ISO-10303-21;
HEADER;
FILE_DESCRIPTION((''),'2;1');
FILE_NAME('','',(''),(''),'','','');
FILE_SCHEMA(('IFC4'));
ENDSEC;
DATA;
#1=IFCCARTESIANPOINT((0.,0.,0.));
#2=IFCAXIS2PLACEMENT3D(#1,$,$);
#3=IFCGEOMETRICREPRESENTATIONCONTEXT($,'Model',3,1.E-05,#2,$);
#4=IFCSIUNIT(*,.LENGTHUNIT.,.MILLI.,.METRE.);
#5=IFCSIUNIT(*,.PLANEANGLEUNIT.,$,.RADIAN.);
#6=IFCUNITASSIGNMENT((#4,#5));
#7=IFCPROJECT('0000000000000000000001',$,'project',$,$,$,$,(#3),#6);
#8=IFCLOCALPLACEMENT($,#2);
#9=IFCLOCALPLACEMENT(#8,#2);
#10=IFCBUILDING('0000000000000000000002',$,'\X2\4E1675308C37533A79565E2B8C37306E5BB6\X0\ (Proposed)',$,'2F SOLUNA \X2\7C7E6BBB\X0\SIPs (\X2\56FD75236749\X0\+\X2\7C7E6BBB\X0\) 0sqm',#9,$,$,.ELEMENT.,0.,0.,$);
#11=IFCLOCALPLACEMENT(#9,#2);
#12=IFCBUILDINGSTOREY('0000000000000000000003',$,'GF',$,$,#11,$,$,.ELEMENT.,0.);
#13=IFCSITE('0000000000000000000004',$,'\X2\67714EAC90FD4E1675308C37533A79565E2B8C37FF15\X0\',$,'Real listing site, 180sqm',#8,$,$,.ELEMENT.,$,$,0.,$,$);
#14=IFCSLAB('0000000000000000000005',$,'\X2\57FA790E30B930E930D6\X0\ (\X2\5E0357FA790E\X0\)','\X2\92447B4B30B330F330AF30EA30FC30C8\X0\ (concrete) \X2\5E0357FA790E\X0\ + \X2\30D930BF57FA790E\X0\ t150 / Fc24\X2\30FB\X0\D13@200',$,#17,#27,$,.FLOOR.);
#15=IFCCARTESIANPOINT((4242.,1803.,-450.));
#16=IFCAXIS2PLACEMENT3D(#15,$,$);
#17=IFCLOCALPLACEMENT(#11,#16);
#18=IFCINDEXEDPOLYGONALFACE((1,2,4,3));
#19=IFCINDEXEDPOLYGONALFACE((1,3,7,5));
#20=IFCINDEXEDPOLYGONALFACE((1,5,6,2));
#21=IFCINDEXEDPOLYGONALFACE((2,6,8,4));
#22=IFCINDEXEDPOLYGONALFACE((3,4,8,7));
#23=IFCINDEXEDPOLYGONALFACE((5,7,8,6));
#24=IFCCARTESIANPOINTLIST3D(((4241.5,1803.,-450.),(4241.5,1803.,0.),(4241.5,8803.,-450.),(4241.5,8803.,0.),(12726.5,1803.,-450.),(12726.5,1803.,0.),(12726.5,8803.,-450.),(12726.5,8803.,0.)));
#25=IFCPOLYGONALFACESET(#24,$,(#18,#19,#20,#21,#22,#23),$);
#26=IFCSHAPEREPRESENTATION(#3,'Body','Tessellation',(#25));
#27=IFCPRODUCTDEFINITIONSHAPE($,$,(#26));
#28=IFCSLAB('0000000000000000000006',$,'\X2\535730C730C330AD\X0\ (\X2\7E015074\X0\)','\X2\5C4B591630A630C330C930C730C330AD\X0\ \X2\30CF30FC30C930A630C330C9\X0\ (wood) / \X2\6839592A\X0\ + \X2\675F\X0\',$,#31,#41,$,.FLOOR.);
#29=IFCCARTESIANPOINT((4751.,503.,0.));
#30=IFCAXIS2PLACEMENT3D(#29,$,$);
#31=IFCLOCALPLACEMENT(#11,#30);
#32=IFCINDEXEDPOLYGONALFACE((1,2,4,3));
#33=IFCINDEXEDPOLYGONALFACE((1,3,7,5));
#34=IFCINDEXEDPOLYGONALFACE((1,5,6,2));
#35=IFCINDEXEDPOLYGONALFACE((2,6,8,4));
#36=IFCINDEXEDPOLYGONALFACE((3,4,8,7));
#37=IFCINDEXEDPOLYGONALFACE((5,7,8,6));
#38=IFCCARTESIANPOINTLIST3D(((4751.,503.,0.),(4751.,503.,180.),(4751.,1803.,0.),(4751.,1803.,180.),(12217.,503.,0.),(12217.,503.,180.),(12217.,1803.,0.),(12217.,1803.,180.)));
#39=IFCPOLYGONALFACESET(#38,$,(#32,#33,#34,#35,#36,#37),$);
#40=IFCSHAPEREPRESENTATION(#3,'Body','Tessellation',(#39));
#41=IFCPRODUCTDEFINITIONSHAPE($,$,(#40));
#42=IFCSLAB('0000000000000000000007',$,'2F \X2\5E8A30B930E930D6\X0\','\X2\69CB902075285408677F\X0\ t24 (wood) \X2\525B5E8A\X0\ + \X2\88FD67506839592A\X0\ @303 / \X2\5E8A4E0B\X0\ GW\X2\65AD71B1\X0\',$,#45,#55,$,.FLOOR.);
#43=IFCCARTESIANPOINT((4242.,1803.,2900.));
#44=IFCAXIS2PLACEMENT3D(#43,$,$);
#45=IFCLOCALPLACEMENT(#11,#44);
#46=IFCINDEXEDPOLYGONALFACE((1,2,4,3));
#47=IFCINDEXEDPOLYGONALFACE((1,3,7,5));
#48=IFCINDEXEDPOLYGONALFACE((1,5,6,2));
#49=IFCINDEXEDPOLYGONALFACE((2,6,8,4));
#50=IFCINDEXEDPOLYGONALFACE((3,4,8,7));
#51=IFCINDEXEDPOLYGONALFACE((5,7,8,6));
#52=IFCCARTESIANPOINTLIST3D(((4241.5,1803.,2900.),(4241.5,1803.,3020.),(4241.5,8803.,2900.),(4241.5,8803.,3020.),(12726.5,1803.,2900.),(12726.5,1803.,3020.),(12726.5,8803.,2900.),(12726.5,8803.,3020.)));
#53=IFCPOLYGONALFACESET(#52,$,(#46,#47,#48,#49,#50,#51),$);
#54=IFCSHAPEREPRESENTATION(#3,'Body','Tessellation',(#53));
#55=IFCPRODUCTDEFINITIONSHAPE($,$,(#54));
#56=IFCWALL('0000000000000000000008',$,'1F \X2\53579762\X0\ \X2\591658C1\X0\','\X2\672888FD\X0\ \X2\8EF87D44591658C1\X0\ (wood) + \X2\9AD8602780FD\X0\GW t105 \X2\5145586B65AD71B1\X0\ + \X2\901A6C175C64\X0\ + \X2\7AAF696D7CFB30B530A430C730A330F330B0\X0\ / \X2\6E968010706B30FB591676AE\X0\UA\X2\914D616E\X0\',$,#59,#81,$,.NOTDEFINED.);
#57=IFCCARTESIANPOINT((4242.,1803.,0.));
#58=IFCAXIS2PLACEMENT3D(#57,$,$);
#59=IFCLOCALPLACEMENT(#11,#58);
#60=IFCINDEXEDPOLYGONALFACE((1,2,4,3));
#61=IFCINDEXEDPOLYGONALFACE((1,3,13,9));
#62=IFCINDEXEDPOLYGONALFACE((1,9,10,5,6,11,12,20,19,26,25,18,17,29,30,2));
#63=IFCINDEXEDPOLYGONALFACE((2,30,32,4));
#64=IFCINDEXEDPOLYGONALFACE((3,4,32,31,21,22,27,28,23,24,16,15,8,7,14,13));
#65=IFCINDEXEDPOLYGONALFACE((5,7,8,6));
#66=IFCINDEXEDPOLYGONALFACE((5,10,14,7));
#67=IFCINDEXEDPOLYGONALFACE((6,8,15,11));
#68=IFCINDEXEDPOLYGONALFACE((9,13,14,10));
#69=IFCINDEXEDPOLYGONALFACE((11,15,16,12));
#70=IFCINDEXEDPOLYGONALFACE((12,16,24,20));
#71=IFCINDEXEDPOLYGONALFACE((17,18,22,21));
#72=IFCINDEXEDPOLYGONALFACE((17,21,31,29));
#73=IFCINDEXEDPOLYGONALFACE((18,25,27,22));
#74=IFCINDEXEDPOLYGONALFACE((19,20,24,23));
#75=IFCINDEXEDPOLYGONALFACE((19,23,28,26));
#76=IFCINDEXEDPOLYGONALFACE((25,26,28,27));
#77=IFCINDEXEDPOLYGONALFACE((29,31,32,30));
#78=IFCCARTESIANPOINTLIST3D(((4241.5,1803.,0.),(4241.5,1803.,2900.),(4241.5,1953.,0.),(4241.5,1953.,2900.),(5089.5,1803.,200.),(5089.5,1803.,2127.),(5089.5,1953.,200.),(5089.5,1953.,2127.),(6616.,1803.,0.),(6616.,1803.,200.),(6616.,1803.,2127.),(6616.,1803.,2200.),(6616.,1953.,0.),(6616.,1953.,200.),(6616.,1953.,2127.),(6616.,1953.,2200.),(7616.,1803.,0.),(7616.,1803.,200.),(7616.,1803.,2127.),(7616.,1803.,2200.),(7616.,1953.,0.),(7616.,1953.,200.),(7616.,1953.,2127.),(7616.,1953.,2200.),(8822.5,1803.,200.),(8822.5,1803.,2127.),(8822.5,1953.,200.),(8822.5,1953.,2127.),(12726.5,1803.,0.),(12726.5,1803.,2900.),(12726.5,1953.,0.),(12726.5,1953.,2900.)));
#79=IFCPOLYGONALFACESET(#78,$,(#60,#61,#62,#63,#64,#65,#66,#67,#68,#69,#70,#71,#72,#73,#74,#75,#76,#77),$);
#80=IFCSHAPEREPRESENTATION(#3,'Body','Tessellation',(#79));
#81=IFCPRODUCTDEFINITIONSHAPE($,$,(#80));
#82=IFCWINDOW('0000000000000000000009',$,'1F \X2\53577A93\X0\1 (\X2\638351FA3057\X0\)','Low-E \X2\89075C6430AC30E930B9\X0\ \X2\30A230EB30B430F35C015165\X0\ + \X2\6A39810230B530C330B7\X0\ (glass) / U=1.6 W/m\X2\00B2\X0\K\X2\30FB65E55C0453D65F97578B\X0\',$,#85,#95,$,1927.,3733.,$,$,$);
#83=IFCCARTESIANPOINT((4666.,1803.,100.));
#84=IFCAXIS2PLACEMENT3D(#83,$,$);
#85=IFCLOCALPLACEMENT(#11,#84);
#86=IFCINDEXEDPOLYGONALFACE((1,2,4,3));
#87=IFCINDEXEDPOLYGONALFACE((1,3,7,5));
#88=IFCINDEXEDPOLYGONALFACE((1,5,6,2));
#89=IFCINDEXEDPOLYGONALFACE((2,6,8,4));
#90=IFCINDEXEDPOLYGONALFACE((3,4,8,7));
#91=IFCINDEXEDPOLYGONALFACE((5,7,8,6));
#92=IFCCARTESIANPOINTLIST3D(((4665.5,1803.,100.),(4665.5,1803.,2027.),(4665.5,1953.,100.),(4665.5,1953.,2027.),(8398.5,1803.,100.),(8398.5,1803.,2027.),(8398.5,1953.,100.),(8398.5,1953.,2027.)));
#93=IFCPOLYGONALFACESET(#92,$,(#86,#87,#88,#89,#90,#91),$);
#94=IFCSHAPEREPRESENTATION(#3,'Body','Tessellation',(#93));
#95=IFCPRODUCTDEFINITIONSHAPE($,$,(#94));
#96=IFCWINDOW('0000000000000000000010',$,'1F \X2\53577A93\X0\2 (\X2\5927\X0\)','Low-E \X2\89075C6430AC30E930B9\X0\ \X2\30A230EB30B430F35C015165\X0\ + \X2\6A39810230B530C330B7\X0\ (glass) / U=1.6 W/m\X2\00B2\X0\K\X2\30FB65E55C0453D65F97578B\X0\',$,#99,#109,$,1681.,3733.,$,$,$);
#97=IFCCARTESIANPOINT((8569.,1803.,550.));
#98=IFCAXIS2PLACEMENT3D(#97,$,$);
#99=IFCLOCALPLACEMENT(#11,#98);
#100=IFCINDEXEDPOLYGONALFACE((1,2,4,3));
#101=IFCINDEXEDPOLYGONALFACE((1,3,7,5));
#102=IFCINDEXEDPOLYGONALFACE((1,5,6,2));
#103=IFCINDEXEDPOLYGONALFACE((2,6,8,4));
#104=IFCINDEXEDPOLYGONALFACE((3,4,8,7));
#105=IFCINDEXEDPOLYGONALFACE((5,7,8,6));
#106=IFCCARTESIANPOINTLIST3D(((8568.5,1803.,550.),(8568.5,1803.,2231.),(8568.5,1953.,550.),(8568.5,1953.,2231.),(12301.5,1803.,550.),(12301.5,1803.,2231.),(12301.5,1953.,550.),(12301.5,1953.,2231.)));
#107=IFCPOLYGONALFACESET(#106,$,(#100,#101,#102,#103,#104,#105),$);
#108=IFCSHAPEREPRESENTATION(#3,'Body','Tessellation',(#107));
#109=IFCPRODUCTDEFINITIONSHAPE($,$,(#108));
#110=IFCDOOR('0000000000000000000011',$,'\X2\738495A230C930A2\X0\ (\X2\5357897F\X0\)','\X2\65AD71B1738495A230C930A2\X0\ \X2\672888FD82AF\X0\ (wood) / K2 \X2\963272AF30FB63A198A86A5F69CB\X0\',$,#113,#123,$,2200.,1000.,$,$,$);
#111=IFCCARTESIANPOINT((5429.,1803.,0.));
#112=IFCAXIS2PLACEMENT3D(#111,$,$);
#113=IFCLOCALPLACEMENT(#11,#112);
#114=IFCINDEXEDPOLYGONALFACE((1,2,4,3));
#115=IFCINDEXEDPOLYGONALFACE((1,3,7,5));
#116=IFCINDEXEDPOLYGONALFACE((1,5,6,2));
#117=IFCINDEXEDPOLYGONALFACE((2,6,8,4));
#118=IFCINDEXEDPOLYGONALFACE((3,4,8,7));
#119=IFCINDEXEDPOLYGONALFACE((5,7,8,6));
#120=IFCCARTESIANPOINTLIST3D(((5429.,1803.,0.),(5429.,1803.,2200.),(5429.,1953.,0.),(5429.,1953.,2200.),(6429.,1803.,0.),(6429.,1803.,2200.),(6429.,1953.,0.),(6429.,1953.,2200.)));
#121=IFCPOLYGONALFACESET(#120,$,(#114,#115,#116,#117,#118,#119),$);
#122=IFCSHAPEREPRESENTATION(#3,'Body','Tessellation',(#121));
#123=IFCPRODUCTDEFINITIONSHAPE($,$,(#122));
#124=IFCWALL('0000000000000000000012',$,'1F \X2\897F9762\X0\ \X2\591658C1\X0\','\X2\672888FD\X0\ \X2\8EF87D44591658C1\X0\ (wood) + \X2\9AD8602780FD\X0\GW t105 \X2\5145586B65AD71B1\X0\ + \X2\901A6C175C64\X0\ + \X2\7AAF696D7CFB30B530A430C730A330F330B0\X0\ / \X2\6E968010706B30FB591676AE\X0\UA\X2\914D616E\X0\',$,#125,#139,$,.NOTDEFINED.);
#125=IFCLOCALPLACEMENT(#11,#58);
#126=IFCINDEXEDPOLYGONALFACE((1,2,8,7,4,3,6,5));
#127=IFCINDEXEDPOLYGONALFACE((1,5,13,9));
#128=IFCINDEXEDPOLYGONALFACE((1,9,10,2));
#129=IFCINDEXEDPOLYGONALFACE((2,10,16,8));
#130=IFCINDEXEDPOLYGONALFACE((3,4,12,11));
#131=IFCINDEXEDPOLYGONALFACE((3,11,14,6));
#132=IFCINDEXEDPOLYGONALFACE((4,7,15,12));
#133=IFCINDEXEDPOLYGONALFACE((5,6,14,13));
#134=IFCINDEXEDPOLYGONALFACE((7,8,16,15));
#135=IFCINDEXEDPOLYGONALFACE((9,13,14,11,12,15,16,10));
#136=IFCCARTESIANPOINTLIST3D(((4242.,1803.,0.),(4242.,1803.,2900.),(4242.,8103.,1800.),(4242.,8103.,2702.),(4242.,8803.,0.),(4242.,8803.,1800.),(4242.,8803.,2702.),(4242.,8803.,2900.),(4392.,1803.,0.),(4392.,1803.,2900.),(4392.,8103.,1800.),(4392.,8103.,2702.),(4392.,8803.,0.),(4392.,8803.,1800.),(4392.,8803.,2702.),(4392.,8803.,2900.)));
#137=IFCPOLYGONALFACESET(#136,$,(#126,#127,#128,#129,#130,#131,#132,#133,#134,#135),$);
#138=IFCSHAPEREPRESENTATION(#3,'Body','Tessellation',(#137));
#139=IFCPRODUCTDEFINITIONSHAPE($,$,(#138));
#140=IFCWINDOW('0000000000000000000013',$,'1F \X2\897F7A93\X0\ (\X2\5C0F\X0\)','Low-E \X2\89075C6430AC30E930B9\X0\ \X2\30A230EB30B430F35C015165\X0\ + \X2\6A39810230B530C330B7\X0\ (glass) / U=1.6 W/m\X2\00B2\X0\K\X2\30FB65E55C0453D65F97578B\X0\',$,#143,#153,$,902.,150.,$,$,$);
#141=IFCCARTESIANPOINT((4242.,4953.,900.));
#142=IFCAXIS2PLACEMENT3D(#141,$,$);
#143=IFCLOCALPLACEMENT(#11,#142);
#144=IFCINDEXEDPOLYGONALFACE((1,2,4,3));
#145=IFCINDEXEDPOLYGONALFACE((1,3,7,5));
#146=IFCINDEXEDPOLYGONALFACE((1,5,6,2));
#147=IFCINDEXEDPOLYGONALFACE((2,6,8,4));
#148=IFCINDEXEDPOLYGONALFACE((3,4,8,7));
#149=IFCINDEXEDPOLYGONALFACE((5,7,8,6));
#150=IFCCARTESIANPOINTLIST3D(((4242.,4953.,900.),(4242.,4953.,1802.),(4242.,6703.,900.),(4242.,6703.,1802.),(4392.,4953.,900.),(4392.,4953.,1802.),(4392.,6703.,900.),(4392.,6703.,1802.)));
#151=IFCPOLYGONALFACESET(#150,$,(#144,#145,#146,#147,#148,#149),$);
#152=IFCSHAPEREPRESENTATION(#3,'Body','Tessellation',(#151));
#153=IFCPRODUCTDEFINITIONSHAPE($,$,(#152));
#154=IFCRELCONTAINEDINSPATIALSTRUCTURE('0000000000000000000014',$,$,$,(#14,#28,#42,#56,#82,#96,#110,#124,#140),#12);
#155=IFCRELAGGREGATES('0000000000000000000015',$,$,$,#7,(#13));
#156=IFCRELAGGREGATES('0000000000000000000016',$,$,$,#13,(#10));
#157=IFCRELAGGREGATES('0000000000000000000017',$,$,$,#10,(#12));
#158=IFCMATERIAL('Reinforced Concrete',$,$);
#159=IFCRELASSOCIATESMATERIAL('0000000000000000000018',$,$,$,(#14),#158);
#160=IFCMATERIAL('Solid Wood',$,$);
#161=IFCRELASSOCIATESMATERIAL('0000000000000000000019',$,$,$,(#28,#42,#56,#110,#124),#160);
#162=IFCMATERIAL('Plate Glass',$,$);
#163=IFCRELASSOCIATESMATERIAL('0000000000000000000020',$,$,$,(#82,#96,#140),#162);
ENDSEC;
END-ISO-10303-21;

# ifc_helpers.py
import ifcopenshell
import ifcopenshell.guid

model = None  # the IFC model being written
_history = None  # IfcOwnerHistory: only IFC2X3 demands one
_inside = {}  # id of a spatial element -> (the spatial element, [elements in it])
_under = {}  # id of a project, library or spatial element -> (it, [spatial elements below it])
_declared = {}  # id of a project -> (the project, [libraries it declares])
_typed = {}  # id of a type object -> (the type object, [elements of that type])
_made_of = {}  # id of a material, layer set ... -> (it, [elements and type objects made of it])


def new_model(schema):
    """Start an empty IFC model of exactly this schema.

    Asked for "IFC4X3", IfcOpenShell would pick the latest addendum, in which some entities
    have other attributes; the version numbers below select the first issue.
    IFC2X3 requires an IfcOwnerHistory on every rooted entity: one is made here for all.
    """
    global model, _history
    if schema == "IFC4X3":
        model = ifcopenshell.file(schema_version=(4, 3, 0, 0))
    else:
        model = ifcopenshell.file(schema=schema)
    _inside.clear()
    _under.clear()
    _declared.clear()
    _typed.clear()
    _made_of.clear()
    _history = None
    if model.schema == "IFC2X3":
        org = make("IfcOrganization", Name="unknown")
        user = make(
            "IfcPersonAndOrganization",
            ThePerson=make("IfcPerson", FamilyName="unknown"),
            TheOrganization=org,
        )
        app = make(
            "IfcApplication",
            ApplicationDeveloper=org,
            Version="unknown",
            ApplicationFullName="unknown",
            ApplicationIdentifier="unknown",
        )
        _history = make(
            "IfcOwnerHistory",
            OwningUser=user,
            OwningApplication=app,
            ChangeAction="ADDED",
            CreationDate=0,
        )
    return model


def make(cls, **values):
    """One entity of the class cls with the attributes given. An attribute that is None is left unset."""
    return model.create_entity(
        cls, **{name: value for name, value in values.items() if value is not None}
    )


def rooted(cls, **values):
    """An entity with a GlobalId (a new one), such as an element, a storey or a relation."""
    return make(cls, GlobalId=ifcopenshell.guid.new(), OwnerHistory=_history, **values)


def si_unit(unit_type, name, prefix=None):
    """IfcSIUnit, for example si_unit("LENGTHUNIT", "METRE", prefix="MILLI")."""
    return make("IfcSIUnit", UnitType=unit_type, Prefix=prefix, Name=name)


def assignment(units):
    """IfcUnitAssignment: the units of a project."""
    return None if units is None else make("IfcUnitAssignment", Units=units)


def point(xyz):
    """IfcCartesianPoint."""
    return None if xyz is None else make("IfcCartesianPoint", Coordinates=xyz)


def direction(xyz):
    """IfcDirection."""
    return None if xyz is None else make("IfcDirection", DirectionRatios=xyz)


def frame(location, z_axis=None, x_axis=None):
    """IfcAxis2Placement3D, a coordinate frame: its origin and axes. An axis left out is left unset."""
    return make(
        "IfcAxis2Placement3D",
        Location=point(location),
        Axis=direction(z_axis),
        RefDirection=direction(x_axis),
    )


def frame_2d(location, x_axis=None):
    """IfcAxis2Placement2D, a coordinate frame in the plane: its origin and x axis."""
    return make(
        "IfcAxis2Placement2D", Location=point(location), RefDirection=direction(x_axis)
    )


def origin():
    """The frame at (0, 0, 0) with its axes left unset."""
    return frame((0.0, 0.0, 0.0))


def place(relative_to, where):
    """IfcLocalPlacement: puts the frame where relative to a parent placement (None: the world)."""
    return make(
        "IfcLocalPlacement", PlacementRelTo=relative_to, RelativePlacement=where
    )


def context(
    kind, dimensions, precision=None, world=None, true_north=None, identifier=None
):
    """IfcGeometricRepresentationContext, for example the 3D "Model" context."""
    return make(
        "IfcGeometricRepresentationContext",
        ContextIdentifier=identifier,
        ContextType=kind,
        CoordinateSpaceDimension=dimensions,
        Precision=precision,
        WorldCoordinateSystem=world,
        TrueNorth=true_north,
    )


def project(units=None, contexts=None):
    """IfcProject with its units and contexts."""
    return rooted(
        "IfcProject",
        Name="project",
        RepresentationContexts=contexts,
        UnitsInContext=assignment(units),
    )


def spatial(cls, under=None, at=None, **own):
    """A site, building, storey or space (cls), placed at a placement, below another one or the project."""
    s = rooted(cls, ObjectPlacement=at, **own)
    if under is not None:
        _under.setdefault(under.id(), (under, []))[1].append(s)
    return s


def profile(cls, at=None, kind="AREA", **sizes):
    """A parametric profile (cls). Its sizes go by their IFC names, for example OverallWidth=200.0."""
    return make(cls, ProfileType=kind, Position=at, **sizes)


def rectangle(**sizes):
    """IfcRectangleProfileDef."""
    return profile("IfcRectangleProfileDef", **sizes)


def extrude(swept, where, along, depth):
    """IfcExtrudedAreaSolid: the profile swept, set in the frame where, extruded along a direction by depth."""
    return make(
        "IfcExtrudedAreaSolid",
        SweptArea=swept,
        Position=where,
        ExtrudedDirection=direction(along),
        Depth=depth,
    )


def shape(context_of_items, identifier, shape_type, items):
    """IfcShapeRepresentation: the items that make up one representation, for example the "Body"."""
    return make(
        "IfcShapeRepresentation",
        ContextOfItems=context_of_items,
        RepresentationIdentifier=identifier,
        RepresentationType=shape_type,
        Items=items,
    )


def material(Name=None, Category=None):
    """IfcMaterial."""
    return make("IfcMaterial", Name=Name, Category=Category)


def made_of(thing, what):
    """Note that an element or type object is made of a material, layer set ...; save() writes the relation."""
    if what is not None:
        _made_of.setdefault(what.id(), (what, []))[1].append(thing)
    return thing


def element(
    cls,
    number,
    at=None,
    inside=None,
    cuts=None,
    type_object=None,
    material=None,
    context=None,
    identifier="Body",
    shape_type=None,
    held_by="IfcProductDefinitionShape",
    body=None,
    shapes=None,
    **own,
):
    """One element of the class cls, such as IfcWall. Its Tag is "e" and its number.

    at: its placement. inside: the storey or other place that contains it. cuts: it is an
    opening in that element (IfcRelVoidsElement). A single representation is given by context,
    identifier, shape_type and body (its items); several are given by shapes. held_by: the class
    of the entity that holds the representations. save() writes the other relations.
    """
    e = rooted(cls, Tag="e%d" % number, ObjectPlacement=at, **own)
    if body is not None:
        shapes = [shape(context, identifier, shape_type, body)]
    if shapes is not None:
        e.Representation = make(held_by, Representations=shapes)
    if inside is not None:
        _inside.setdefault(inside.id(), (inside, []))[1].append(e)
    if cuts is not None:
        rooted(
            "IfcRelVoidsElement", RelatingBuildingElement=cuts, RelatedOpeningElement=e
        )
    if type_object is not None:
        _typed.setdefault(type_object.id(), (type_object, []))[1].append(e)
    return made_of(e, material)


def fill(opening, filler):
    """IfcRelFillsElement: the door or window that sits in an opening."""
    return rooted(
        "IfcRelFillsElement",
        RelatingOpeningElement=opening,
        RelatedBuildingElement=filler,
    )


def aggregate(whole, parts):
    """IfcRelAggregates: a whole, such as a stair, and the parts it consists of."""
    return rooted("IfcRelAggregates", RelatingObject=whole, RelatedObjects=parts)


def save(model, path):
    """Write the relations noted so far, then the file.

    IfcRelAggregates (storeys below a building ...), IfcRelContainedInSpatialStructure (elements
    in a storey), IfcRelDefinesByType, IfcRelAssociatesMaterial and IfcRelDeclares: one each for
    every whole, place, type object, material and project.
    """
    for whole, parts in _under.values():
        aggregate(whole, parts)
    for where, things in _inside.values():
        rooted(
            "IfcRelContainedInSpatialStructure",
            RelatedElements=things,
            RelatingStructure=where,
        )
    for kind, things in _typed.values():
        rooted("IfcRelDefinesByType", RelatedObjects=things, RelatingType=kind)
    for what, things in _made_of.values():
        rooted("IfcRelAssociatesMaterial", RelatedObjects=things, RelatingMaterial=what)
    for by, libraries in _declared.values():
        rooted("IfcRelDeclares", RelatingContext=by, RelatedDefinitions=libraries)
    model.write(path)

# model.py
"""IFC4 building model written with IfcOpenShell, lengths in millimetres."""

from ifc_helpers import new_model, si_unit, frame, frame_2d, origin, place, context, project, spatial, rectangle, extrude, material, element, fill, save


model = new_model("IFC4")

# Units and contexts
model_context = context("Model", 3, precision=1e-05, world=origin())
ifc_project = project(units=[si_unit("LENGTHUNIT", "METRE", prefix="MILLI"), si_unit("PLANEANGLEUNIT", "RADIAN")], contexts=[model_context])

# Site, building, storey
site_placement = place(None, origin())
site = spatial("IfcSite", under=ifc_project, at=site_placement, Name="東京都世田谷区祖師谷５", ObjectType="Real listing site, 180sqm", CompositionType="ELEMENT", RefElevation=0.0)
building_placement = place(site_placement, origin())
building = spatial("IfcBuilding", under=site, at=building_placement, Name="世田谷区祖師谷の家 (Proposed)", ObjectType="2F SOLUNA 籾殻SIPs (国産杉+籾殻) 0sqm", CompositionType="ELEMENT", ElevationOfRefHeight=0.0, ElevationOfTerrain=0.0)
storey_placement = place(building_placement, origin())
storey = spatial("IfcBuildingStorey", under=building, at=storey_placement, Name="GF", CompositionType="ELEMENT", Elevation=0.0)

# Slabs
ifc_material_1 = material(Name="Reinforced Concrete")
slab_1_placement = place(storey_placement, frame((4242.0, 1803.0, -450.0)))
element("IfcSlab", 1, at=slab_1_placement, inside=storey, material=ifc_material_1, Name="基礎スラブ (布基礎)", Description="鉄筋コンクリート (concrete) 布基礎 + ベタ基礎 t150 / Fc24・D13@200", PredefinedType="FLOOR", context=model_context, shape_type="SweptSolid", body=[
    extrude(rectangle(XDim=8485.0, YDim=7000.0, at=frame_2d((4242.0, 3500.0))), frame((4242.0, 1803.0, -450.0)), (0.0, 0.0, 1.0), 450.0),
])
ifc_material_2 = material(Name="Solid Wood")
slab_2_placement = place(storey_placement, frame((4751.0, 503.0, 0.0)))
element("IfcSlab", 2, at=slab_2_placement, inside=storey, material=ifc_material_2, Name="南デッキ (縁側)", Description="屋外ウッドデッキ ハードウッド (wood) / 根太 + 束", PredefinedType="FLOOR", context=model_context, shape_type="SweptSolid", body=[
    extrude(rectangle(XDim=7466.0, YDim=1300.0, at=frame_2d((3733.0, 650.0))), frame((4751.0, 503.0, 0.0)), (0.0, 0.0, 1.0), 180.0),
])
slab_3_placement = place(storey_placement, frame((4242.0, 1803.0, 2900.0)))
element("IfcSlab", 3, at=slab_3_placement, inside=storey, material=ifc_material_2, Name="2F 床スラブ", Description="構造用合板 t24 (wood) 剛床 + 製材根太 @303 / 床下 GW断熱", PredefinedType="FLOOR", context=model_context, shape_type="SweptSolid", body=[
    extrude(rectangle(XDim=8485.0, YDim=7000.0, at=frame_2d((4242.0, 3500.0))), frame((4242.0, 1803.0, 2900.0)), (0.0, 0.0, 1.0), 120.0),
])

# Wall, openings, windows, door
wall_1_placement = place(storey_placement, frame((4242.0, 1803.0, 0.0)))
wall_1 = element("IfcWall", 4, at=wall_1_placement, inside=storey, material=ifc_material_2, Name="1F 南面 外壁", Description="木製 軸組外壁 (wood) + 高性能GW t105 充填断熱 + 通気層 + 窯業系サイディング / 準耐火・外皮UA配慮", PredefinedType="NOTDEFINED", context=model_context, shape_type="SweptSolid", body=[
    extrude(rectangle(XDim=8485.0, YDim=150.0, at=frame_2d((4242.0, 75.0))), frame((4242.0, 1803.0, 0.0)), (0.0, 0.0, 1.0), 2900.0),
])
opening_1_placement = place(storey_placement, frame((4666.0, 1803.0, 100.0)))
opening_1 = element("IfcOpeningElement", 5, at=opening_1_placement, cuts=wall_1, PredefinedType="NOTDEFINED", context=model_context, shape_type="SweptSolid", body=[
    extrude(rectangle(XDim=3733.0, YDim=150.0, at=frame_2d((1866.0, 75.0))), frame((4666.0, 1803.0, 100.0)), (0.0, 0.0, 1.0), 1927.0),
])
opening_2_placement = place(storey_placement, frame((8569.0, 1803.0, 550.0)))
opening_2 = element("IfcOpeningElement", 6, at=opening_2_placement, cuts=wall_1, PredefinedType="NOTDEFINED", context=model_context, shape_type="SweptSolid", body=[
    extrude(rectangle(XDim=3733.0, YDim=150.0, at=frame_2d((1866.0, 75.0))), frame((8569.0, 1803.0, 550.0)), (0.0, 0.0, 1.0), 1681.0),
])
opening_3_placement = place(storey_placement, frame((5429.0, 1803.0, 0.0)))
opening_3 = element("IfcOpeningElement", 7, at=opening_3_placement, cuts=wall_1, PredefinedType="NOTDEFINED", context=model_context, shape_type="SweptSolid", body=[
    extrude(rectangle(XDim=1000.0, YDim=150.0, at=frame_2d((500.0, 75.0))), frame((5429.0, 1803.0, 0.0)), (0.0, 0.0, 1.0), 2200.0),
])
ifc_material_3 = material(Name="Plate Glass")
window_1_placement = place(storey_placement, frame((4666.0, 1803.0, 100.0)))
window_1 = element("IfcWindow", 8, at=window_1_placement, inside=storey, material=ifc_material_3, Name="1F 南窓1 (掃出し)", Description="Low-E 複層ガラス アルゴン封入 + 樹脂サッシ (glass) / U=1.6 W/m²K・日射取得型", OverallHeight=1927.0, OverallWidth=3733.0, context=model_context, shape_type="SweptSolid", body=[
    extrude(rectangle(XDim=3733.0, YDim=150.0, at=frame_2d((1866.0, 75.0))), frame((4666.0, 1803.0, 100.0)), (0.0, 0.0, 1.0), 1927.0),
])
fill(opening_1, window_1)
window_2_placement = place(storey_placement, frame((8569.0, 1803.0, 550.0)))
window_2 = element("IfcWindow", 9, at=window_2_placement, inside=storey, material=ifc_material_3, Name="1F 南窓2 (大)", Description="Low-E 複層ガラス アルゴン封入 + 樹脂サッシ (glass) / U=1.6 W/m²K・日射取得型", OverallHeight=1681.0, OverallWidth=3733.0, context=model_context, shape_type="SweptSolid", body=[
    extrude(rectangle(XDim=3733.0, YDim=150.0, at=frame_2d((1866.0, 75.0))), frame((8569.0, 1803.0, 550.0)), (0.0, 0.0, 1.0), 1681.0),
])
fill(opening_2, window_2)
door_placement = place(storey_placement, frame((5429.0, 1803.0, 0.0)))
door = element("IfcDoor", 10, at=door_placement, inside=storey, material=ifc_material_2, Name="玄関ドア (南西)", Description="断熱玄関ドア 木製芯 (wood) / K2 防犯・採風機構", OverallHeight=2200.0, OverallWidth=1000.0, context=model_context, shape_type="SweptSolid", body=[
    extrude(rectangle(XDim=1000.0, YDim=150.0, at=frame_2d((500.0, 75.0))), frame((5429.0, 1803.0, 0.0)), (0.0, 0.0, 1.0), 2200.0),
])
fill(opening_3, door)

# Wall, opening, window
wall_2_placement = place(storey_placement, frame((4242.0, 1803.0, 0.0)))
wall_2 = element("IfcWall", 11, at=wall_2_placement, inside=storey, material=ifc_material_2, Name="1F 西面 外壁", Description="木製 軸組外壁 (wood) + 高性能GW t105 充填断熱 + 通気層 + 窯業系サイディング / 準耐火・外皮UA配慮", PredefinedType="NOTDEFINED", context=model_context, shape_type="SweptSolid", body=[
    extrude(rectangle(XDim=150.0, YDim=7000.0, at=frame_2d((75.0, 3500.0))), frame((4242.0, 1803.0, 0.0)), (0.0, 0.0, 1.0), 2900.0),
])
opening_4_placement = place(storey_placement, frame((4242.0, 4953.0, 900.0)))
opening_4 = element("IfcOpeningElement", 12, at=opening_4_placement, cuts=wall_2, PredefinedType="NOTDEFINED", context=model_context, shape_type="SweptSolid", body=[
    extrude(rectangle(XDim=150.0, YDim=1750.0, at=frame_2d((75.0, 875.0))), frame((4242.0, 4953.0, 900.0)), (0.0, 0.0, 1.0), 902.0),
])
window_3_placement = place(storey_placement, frame((4242.0, 4953.0, 900.0)))
window_3 = element("IfcWindow", 13, at=window_3_placement, inside=storey, material=ifc_material_3, Name="1F 西窓 (小)", Description="Low-E 複層ガラス アルゴン封入 + 樹脂サッシ (glass) / U=1.6 W/m²K・日射取得型", OverallHeight=902.0, OverallWidth=150.0, context=model_context, shape_type="SweptSolid", body=[
    extrude(rectangle(XDim=150.0, YDim=1750.0, at=frame_2d((75.0, 875.0))), frame((4242.0, 4953.0, 900.0)), (0.0, 0.0, 1.0), 902.0),
])
fill(opening_4, window_3)

save(model, "model.ifc")
